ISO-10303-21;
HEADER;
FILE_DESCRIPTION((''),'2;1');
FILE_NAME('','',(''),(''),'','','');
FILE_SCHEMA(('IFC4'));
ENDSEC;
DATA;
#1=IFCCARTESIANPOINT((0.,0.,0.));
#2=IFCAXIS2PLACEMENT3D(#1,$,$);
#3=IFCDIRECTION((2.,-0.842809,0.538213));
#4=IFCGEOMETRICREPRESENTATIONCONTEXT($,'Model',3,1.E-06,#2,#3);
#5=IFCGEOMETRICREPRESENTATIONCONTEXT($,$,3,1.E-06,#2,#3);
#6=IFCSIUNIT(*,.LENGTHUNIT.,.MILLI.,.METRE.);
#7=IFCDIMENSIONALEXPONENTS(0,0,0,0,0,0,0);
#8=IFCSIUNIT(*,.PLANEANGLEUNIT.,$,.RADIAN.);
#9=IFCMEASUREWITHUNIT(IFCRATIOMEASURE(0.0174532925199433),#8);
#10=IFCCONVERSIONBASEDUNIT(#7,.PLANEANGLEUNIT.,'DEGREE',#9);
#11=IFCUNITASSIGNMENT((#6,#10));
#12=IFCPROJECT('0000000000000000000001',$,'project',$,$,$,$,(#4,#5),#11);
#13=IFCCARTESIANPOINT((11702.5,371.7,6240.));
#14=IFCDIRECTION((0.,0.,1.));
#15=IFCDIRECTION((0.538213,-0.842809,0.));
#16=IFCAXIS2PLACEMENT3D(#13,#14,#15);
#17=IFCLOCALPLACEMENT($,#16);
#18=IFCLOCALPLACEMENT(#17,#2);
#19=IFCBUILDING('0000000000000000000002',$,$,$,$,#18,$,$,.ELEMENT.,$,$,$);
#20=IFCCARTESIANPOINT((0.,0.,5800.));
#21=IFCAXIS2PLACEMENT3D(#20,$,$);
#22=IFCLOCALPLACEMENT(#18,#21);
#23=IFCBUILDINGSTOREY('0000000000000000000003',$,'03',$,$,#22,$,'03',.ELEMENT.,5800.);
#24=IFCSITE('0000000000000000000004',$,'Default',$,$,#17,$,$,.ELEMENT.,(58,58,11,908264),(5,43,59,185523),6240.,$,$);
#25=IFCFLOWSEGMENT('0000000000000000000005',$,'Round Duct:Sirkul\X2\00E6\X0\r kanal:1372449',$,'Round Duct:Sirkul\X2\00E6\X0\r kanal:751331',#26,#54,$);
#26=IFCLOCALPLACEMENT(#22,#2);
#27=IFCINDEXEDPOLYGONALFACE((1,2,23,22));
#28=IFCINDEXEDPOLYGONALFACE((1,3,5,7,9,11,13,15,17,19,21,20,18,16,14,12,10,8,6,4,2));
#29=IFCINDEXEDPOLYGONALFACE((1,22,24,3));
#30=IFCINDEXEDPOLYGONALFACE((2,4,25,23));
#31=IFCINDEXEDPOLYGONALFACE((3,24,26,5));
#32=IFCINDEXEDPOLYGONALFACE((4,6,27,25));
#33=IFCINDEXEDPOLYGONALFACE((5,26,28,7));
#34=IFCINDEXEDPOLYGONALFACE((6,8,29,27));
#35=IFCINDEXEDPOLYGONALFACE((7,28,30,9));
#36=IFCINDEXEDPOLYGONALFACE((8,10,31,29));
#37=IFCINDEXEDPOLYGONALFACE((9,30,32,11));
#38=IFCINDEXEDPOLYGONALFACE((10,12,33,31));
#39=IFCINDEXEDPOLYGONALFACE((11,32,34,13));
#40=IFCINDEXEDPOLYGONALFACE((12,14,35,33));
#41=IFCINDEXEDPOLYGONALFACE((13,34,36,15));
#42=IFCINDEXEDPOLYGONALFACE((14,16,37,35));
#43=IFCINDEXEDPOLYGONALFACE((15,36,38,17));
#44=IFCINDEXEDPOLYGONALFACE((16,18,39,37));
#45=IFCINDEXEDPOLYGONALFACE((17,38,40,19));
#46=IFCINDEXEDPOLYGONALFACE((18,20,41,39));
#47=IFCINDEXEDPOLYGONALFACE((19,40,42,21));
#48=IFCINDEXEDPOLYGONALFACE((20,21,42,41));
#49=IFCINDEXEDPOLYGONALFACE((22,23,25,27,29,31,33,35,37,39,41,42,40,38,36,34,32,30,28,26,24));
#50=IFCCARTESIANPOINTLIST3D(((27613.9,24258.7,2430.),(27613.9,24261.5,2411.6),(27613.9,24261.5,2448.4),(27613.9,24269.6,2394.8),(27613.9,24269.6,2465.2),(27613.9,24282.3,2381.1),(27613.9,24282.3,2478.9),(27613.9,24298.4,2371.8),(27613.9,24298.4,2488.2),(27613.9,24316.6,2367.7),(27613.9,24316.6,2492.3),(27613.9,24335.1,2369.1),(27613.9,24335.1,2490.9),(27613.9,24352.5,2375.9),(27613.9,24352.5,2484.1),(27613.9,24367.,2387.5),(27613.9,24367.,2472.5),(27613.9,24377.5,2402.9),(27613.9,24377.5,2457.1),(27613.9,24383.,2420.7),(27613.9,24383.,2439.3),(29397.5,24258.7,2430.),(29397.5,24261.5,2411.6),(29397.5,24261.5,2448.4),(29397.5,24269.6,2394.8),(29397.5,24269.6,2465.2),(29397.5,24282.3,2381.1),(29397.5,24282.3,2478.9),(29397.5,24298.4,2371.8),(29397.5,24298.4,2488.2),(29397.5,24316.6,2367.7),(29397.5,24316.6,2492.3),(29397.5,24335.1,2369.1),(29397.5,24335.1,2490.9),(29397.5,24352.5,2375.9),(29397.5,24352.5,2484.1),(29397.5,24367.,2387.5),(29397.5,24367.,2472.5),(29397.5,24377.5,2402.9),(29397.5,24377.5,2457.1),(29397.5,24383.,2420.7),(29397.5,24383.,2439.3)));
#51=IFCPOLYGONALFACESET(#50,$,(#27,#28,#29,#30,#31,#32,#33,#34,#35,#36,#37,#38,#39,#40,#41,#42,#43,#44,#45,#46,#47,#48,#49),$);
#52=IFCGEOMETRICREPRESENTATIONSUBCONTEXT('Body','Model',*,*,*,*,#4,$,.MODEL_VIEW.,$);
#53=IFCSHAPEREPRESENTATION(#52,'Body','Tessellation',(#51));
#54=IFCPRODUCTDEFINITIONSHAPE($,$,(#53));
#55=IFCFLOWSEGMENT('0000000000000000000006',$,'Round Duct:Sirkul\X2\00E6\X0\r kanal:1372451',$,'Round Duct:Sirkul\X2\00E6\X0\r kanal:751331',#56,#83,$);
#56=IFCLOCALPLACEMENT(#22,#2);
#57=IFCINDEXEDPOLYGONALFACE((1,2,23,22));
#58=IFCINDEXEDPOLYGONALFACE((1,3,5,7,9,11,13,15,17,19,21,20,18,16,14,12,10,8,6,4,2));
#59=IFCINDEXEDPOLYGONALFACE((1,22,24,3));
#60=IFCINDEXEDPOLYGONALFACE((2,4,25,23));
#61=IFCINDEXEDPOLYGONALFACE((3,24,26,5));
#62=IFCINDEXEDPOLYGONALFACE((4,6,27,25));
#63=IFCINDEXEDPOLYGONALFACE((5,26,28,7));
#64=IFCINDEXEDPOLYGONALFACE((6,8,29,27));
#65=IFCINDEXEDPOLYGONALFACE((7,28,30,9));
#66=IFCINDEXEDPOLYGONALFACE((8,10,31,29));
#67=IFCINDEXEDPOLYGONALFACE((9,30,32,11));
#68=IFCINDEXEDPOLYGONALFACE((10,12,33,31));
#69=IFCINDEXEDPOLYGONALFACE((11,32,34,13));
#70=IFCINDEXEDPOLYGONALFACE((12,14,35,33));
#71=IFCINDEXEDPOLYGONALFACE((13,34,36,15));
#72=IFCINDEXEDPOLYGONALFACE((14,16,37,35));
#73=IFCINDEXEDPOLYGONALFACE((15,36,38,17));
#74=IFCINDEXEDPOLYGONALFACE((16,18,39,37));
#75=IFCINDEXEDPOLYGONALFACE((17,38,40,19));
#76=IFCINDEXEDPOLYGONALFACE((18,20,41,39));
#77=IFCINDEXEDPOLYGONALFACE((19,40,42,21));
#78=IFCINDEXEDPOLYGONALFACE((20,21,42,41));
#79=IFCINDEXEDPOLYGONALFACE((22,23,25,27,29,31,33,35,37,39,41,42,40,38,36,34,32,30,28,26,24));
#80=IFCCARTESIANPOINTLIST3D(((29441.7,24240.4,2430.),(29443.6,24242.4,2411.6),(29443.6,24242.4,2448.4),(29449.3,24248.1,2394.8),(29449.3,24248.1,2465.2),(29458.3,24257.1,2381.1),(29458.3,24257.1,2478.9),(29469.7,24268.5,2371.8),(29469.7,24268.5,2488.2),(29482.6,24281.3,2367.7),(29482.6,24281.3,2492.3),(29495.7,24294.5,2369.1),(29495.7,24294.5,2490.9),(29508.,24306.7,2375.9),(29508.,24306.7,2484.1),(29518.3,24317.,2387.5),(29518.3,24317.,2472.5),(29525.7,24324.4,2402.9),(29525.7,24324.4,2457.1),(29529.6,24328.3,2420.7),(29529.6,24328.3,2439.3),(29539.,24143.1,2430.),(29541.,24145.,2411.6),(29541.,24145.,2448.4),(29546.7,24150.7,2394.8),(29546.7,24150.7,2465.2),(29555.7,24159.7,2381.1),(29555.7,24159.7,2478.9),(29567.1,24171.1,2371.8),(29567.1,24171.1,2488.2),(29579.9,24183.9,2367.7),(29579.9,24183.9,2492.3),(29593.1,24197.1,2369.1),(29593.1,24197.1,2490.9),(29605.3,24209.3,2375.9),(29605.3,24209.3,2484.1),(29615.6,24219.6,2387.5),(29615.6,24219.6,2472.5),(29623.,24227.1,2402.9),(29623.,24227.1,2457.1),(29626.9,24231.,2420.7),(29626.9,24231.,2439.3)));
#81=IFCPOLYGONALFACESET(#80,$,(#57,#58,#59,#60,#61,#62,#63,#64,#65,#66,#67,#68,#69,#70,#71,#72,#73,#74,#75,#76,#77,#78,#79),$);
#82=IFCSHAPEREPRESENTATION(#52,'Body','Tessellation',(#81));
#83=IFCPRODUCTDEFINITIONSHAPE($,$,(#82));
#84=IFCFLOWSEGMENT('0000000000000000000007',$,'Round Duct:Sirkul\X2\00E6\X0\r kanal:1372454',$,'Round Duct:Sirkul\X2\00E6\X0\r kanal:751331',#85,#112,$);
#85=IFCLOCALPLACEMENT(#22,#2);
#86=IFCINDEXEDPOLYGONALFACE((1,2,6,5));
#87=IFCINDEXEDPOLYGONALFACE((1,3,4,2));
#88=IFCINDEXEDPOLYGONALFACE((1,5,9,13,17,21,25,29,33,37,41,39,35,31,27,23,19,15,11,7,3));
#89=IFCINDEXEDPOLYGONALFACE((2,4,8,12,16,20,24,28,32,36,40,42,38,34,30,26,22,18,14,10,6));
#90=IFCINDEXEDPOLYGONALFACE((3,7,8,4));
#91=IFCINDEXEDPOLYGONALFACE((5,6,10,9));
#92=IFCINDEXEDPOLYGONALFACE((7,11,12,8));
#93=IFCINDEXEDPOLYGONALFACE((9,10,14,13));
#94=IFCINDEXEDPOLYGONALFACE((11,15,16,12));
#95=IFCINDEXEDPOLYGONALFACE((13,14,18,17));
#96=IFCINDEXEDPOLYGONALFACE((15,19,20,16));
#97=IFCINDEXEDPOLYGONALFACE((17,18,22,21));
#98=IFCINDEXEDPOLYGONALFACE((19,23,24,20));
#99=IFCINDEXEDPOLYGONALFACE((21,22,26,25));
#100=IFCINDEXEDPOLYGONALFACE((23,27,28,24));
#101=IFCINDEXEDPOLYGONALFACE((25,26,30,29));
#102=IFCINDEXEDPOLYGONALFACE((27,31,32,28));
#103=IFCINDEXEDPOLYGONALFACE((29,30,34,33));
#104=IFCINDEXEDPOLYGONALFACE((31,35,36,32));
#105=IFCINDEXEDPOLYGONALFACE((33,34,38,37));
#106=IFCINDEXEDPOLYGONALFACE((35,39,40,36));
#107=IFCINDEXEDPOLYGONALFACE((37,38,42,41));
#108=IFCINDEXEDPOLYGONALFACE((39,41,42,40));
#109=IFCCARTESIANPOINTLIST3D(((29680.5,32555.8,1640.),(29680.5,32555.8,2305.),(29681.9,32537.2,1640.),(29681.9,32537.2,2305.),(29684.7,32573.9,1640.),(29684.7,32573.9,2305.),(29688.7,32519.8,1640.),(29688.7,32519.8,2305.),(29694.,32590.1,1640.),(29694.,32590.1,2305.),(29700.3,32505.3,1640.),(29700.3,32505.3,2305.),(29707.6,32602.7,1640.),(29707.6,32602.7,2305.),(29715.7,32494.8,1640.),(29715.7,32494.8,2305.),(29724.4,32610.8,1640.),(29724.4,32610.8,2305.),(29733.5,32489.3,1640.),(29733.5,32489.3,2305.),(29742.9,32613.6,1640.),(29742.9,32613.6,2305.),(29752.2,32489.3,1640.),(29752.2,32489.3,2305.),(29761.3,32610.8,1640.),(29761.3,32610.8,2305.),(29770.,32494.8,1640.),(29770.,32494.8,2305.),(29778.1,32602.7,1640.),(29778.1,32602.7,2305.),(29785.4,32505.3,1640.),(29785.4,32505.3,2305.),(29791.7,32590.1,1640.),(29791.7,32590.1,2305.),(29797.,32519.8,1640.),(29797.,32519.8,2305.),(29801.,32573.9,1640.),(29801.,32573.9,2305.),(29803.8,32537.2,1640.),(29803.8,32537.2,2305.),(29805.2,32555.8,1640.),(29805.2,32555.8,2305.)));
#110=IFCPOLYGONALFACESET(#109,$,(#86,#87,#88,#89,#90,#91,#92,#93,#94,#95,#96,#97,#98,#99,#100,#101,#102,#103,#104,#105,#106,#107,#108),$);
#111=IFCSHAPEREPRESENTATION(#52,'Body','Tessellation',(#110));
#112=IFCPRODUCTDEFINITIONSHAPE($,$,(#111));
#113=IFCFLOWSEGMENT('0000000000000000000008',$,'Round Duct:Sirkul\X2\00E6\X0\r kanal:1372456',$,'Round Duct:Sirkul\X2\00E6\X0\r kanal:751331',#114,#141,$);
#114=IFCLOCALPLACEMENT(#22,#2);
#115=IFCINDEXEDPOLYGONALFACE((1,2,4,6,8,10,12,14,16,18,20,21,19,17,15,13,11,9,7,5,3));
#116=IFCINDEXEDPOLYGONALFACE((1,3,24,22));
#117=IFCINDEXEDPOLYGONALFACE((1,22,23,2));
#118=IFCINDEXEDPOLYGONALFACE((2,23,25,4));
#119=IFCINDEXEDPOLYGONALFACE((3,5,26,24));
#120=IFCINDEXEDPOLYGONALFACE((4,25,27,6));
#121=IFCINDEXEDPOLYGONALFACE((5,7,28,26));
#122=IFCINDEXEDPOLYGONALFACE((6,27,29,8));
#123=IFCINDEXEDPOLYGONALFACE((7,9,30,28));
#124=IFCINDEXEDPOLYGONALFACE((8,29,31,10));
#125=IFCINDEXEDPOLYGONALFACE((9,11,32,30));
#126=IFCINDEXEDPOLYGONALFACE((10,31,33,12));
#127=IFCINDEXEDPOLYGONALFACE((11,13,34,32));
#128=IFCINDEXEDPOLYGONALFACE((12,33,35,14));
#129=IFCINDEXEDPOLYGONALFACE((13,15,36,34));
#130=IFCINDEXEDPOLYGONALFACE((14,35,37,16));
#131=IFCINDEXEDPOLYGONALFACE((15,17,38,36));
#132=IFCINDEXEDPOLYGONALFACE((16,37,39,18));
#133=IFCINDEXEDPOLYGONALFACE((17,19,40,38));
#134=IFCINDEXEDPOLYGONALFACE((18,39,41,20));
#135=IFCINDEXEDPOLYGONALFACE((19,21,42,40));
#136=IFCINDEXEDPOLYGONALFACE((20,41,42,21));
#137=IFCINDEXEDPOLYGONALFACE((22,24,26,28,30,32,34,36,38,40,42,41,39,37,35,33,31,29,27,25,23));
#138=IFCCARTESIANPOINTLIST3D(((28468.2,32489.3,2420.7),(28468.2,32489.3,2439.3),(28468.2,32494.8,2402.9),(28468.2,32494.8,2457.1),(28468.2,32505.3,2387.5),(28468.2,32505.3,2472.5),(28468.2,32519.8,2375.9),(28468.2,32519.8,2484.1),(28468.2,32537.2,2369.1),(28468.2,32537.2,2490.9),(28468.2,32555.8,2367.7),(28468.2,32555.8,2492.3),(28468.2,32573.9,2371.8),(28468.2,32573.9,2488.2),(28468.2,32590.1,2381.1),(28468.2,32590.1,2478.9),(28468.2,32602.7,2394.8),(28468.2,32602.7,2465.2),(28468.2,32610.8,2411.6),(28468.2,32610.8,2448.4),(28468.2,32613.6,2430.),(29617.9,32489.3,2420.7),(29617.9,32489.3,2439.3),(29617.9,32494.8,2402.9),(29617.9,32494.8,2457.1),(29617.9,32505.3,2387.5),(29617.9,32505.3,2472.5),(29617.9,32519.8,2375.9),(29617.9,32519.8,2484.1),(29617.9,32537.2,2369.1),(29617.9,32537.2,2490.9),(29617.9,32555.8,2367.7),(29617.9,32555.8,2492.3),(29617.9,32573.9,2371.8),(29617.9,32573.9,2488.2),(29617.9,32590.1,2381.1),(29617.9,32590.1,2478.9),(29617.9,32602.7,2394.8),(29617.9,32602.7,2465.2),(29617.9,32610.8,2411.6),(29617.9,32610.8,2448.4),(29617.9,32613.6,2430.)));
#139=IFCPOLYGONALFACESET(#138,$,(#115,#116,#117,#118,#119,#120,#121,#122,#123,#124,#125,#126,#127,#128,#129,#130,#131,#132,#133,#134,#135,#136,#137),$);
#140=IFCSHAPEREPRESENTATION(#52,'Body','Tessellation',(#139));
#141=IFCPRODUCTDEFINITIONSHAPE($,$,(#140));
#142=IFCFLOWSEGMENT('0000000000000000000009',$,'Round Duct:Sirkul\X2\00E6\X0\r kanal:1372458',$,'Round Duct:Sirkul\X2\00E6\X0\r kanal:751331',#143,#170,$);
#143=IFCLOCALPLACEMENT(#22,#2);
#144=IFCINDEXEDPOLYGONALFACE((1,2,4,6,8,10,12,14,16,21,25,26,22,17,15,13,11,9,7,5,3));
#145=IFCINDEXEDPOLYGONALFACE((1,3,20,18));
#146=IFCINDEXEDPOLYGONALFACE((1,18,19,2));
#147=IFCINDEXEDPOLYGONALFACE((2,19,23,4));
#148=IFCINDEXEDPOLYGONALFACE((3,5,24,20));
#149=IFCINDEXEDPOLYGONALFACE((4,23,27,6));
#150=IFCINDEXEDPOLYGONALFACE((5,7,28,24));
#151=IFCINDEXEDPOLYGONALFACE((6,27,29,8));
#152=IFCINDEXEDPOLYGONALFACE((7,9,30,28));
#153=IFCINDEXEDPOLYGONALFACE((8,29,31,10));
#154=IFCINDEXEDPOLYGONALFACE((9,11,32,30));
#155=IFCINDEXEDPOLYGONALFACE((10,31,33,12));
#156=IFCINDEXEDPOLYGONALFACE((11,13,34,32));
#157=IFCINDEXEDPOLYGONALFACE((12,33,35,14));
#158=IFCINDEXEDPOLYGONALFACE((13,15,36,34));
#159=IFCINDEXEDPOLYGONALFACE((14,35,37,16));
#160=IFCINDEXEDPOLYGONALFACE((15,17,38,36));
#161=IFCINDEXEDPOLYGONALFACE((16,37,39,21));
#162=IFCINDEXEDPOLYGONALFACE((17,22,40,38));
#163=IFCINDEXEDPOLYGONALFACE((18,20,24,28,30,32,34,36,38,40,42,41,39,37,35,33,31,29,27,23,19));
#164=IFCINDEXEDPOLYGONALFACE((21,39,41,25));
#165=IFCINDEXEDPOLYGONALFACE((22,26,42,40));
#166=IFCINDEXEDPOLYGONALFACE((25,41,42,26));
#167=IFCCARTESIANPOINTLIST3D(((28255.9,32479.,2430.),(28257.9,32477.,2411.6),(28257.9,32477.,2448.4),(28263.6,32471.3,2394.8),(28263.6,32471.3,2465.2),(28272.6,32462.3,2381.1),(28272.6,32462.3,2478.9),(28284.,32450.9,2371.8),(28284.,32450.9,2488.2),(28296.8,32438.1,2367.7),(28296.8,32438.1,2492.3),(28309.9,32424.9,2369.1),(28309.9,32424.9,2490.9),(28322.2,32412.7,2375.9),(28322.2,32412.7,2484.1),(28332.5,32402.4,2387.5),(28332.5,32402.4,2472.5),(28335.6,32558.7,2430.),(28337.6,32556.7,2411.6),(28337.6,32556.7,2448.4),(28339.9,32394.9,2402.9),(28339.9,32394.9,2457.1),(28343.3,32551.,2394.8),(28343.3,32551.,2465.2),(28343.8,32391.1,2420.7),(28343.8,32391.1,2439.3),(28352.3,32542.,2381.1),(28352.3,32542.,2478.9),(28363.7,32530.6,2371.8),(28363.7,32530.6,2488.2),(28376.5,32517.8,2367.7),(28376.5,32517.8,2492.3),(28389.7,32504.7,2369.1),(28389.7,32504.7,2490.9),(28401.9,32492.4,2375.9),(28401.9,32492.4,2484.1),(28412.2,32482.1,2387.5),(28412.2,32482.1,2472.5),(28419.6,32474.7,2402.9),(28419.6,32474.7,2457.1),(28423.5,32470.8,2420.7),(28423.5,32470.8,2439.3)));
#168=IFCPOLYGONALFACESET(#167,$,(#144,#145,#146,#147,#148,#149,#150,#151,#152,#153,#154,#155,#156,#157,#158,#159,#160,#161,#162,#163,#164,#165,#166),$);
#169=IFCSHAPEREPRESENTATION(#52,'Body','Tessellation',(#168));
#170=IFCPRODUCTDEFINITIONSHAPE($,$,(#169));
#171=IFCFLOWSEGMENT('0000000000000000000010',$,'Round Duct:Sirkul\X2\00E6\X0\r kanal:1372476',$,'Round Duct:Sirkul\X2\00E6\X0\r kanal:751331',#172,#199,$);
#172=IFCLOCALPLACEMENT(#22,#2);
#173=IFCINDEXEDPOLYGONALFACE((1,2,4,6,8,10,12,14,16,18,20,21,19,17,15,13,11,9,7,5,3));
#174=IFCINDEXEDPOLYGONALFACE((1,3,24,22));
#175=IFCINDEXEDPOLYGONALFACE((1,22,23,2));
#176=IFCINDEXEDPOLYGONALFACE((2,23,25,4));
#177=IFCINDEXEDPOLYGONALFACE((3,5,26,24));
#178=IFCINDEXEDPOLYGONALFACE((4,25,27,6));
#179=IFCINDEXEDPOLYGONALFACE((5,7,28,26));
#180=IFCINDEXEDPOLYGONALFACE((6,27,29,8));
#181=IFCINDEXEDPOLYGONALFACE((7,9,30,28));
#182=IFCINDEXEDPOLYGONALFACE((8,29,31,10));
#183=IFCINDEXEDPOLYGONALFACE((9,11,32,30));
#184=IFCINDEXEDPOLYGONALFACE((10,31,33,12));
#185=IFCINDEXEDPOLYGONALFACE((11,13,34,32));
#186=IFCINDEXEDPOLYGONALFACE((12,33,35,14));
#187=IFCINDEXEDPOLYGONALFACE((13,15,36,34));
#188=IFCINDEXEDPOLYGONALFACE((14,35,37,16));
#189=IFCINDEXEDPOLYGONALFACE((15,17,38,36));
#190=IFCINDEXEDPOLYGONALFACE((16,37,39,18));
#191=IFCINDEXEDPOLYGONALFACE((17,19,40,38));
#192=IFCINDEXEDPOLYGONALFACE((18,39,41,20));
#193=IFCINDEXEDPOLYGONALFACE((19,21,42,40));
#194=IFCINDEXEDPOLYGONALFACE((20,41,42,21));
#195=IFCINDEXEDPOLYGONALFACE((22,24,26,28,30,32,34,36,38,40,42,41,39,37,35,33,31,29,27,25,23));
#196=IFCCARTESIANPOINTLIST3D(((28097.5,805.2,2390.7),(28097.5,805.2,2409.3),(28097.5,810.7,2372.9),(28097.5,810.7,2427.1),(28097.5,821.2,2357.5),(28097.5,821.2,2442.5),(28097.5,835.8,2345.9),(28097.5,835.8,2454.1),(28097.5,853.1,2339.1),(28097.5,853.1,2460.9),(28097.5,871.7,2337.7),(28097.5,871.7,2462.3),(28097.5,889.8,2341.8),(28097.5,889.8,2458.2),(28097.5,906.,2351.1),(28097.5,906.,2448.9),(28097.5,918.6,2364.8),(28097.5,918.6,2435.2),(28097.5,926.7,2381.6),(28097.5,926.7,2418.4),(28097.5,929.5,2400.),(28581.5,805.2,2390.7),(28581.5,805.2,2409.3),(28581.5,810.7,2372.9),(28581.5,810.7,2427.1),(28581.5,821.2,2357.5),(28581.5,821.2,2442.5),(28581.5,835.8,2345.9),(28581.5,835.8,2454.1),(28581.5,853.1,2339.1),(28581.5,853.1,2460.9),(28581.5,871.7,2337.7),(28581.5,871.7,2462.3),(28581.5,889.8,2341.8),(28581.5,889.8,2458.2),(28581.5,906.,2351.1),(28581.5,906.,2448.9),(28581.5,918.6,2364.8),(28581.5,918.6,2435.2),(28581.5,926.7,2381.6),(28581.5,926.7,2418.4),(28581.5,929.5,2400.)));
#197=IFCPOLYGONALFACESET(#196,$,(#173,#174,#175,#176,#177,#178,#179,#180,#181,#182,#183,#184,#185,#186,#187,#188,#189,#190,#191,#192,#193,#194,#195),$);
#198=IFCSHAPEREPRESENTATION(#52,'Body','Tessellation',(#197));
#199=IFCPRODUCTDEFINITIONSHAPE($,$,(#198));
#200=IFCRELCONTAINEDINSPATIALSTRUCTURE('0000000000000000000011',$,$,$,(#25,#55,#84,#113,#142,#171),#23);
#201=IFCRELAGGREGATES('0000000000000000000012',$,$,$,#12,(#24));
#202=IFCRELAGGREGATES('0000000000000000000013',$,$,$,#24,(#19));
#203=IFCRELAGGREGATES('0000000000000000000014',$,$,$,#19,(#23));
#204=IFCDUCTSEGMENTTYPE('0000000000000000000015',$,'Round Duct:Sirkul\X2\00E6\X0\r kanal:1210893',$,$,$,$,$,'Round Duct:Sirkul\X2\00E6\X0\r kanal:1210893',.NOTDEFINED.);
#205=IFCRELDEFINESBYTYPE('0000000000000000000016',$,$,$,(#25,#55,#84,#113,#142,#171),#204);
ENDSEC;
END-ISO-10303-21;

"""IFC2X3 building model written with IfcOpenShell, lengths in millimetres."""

from ifc_helpers import new_model, entity, si_unit, converted_unit, direction, frame, frame_2d, origin, origin_2d_with_axis, place, context, subcontext, project, spatial, circle, extrude, type_object, element, save


model = new_model("IFC2X3")

# Units and contexts
model_context = context("Model", 3, precision=1e-06, world=origin(), true_north=direction((2.0, -0.842809, 0.538213)))
context_of_model = context(None, 3, precision=1e-06, world=origin(), true_north=direction((2.0, -0.842809, 0.538213)))
body_context = subcontext(model_context, "Body", "Model", "MODEL_VIEW")
ifc_project = project(units=[si_unit("LENGTHUNIT", "METRE", prefix="MILLI"), converted_unit("PLANEANGLEUNIT", "DEGREE", entity("IfcRatioMeasure", 0.0174532925199433), si_unit("PLANEANGLEUNIT", "RADIAN"), dimensions=[0, 0, 0, 0, 0, 0, 0])], contexts=[model_context, context_of_model])

# Site, building, storey
site_placement = place(None, frame((11702.5, 371.7, 6240.0), z_axis=(0.0, 0.0, 1.0), x_axis=(0.538213, -0.842809, 0.0)))
site = spatial("IfcSite", under=ifc_project, at=site_placement, Name="Default", CompositionType="ELEMENT", RefLatitude=(58, 58, 11, 908264), RefLongitude=(5, 43, 59, 185523), RefElevation=6240.0)
building_placement = place(site_placement, origin())
building = spatial("IfcBuilding", under=site, at=building_placement, CompositionType="ELEMENT")
storey_placement = place(building_placement, frame((0.0, 0.0, 5800.0)))
storey = spatial("IfcBuildingStorey", under=building, at=storey_placement, Name="03", LongName="03", CompositionType="ELEMENT", Elevation=5800.0)

# Flow segments
duct_segment_type_1 = type_object("IfcDuctSegmentType", Name="Round Duct:Sirkulær kanal:1210893", ElementType="Round Duct:Sirkulær kanal:1210893", PredefinedType="NOTDEFINED")
flow_segment_1_placement = place(storey_placement, origin())
element("IfcFlowSegment", 1, at=flow_segment_1_placement, inside=storey, type_object=duct_segment_type_1, Name="Round Duct:Sirkulær kanal:1372449", ObjectType="Round Duct:Sirkulær kanal:751331", context=body_context, shape_type="SweptSolid", body=[
    extrude(circle(Radius=62.5, at=frame_2d((0.0, 0.0), x_axis=(1.0, 0.0))), frame((27613.9, 24321.2, 2430.0), z_axis=(1.0, 0.0, 0.0), x_axis=(0.0, -1.0, 0.0)), (0.0, 0.0, 1.0), 1783.6),
])
flow_segment_2_placement = place(storey_placement, origin())
element("IfcFlowSegment", 2, at=flow_segment_2_placement, inside=storey, type_object=duct_segment_type_1, Name="Round Duct:Sirkulær kanal:1372451", ObjectType="Round Duct:Sirkulær kanal:751331", context=body_context, shape_type="SweptSolid", body=[
    extrude(circle(Radius=62.5, at=origin_2d_with_axis()), frame((29485.9, 24284.6, 2430.0), z_axis=(0.707107, -0.707107, 0.0), x_axis=(-0.707107, -0.707107, 0.0)), (0.0, 0.0, 1.0), 137.7),
])
flow_segment_3_placement = place(storey_placement, origin())
element("IfcFlowSegment", 3, at=flow_segment_3_placement, inside=storey, type_object=duct_segment_type_1, Name="Round Duct:Sirkulær kanal:1372454", ObjectType="Round Duct:Sirkulær kanal:751331", context=body_context, shape_type="SweptSolid", body=[
    extrude(circle(Radius=62.5, at=origin_2d_with_axis()), frame((29742.9, 32551.1, 1640.0), z_axis=(0.0, 0.0, 1.0), x_axis=(0.0, 1.0, 0.0)), (0.0, 0.0, 1.0), 665.0),
])
flow_segment_4_placement = place(storey_placement, origin())
element("IfcFlowSegment", 4, at=flow_segment_4_placement, inside=storey, type_object=duct_segment_type_1, Name="Round Duct:Sirkulær kanal:1372456", ObjectType="Round Duct:Sirkulær kanal:751331", context=body_context, shape_type="SweptSolid", body=[
    extrude(circle(Radius=62.5, at=frame_2d((0.0, 0.0), x_axis=(1.0, 0.0))), frame((28468.2, 32551.1, 2430.0), z_axis=(1.0, 0.0, 0.0), x_axis=(0.0, 1.0, 0.0)), (0.0, 0.0, 1.0), 1149.6),
])
flow_segment_5_placement = place(storey_placement, origin())
element("IfcFlowSegment", 5, at=flow_segment_5_placement, inside=storey, type_object=duct_segment_type_1, Name="Round Duct:Sirkulær kanal:1372458", ObjectType="Round Duct:Sirkulær kanal:751331", context=body_context, shape_type="SweptSolid", body=[
    extrude(circle(Radius=62.5, at=origin_2d_with_axis()), frame((28300.1, 32434.8, 2430.0), z_axis=(0.707107, 0.707107, 0.0), x_axis=(-0.707107, 0.707107, 0.0)), (0.0, 0.0, 1.0), 112.7),
])
flow_segment_6_placement = place(storey_placement, origin())
element("IfcFlowSegment", 6, at=flow_segment_6_placement, inside=storey, type_object=duct_segment_type_1, Name="Round Duct:Sirkulær kanal:1372476", ObjectType="Round Duct:Sirkulær kanal:751331", context=body_context, shape_type="SweptSolid", body=[
    extrude(circle(Radius=62.5, at=frame_2d((0.0, 0.0), x_axis=(1.0, 0.0))), frame((28097.5, 867.0, 2400.0), z_axis=(1.0, 0.0, 0.0), x_axis=(0.0, 1.0, 0.0)), (0.0, 0.0, 1.0), 484.0),
])

save(model, "model.ifc")
